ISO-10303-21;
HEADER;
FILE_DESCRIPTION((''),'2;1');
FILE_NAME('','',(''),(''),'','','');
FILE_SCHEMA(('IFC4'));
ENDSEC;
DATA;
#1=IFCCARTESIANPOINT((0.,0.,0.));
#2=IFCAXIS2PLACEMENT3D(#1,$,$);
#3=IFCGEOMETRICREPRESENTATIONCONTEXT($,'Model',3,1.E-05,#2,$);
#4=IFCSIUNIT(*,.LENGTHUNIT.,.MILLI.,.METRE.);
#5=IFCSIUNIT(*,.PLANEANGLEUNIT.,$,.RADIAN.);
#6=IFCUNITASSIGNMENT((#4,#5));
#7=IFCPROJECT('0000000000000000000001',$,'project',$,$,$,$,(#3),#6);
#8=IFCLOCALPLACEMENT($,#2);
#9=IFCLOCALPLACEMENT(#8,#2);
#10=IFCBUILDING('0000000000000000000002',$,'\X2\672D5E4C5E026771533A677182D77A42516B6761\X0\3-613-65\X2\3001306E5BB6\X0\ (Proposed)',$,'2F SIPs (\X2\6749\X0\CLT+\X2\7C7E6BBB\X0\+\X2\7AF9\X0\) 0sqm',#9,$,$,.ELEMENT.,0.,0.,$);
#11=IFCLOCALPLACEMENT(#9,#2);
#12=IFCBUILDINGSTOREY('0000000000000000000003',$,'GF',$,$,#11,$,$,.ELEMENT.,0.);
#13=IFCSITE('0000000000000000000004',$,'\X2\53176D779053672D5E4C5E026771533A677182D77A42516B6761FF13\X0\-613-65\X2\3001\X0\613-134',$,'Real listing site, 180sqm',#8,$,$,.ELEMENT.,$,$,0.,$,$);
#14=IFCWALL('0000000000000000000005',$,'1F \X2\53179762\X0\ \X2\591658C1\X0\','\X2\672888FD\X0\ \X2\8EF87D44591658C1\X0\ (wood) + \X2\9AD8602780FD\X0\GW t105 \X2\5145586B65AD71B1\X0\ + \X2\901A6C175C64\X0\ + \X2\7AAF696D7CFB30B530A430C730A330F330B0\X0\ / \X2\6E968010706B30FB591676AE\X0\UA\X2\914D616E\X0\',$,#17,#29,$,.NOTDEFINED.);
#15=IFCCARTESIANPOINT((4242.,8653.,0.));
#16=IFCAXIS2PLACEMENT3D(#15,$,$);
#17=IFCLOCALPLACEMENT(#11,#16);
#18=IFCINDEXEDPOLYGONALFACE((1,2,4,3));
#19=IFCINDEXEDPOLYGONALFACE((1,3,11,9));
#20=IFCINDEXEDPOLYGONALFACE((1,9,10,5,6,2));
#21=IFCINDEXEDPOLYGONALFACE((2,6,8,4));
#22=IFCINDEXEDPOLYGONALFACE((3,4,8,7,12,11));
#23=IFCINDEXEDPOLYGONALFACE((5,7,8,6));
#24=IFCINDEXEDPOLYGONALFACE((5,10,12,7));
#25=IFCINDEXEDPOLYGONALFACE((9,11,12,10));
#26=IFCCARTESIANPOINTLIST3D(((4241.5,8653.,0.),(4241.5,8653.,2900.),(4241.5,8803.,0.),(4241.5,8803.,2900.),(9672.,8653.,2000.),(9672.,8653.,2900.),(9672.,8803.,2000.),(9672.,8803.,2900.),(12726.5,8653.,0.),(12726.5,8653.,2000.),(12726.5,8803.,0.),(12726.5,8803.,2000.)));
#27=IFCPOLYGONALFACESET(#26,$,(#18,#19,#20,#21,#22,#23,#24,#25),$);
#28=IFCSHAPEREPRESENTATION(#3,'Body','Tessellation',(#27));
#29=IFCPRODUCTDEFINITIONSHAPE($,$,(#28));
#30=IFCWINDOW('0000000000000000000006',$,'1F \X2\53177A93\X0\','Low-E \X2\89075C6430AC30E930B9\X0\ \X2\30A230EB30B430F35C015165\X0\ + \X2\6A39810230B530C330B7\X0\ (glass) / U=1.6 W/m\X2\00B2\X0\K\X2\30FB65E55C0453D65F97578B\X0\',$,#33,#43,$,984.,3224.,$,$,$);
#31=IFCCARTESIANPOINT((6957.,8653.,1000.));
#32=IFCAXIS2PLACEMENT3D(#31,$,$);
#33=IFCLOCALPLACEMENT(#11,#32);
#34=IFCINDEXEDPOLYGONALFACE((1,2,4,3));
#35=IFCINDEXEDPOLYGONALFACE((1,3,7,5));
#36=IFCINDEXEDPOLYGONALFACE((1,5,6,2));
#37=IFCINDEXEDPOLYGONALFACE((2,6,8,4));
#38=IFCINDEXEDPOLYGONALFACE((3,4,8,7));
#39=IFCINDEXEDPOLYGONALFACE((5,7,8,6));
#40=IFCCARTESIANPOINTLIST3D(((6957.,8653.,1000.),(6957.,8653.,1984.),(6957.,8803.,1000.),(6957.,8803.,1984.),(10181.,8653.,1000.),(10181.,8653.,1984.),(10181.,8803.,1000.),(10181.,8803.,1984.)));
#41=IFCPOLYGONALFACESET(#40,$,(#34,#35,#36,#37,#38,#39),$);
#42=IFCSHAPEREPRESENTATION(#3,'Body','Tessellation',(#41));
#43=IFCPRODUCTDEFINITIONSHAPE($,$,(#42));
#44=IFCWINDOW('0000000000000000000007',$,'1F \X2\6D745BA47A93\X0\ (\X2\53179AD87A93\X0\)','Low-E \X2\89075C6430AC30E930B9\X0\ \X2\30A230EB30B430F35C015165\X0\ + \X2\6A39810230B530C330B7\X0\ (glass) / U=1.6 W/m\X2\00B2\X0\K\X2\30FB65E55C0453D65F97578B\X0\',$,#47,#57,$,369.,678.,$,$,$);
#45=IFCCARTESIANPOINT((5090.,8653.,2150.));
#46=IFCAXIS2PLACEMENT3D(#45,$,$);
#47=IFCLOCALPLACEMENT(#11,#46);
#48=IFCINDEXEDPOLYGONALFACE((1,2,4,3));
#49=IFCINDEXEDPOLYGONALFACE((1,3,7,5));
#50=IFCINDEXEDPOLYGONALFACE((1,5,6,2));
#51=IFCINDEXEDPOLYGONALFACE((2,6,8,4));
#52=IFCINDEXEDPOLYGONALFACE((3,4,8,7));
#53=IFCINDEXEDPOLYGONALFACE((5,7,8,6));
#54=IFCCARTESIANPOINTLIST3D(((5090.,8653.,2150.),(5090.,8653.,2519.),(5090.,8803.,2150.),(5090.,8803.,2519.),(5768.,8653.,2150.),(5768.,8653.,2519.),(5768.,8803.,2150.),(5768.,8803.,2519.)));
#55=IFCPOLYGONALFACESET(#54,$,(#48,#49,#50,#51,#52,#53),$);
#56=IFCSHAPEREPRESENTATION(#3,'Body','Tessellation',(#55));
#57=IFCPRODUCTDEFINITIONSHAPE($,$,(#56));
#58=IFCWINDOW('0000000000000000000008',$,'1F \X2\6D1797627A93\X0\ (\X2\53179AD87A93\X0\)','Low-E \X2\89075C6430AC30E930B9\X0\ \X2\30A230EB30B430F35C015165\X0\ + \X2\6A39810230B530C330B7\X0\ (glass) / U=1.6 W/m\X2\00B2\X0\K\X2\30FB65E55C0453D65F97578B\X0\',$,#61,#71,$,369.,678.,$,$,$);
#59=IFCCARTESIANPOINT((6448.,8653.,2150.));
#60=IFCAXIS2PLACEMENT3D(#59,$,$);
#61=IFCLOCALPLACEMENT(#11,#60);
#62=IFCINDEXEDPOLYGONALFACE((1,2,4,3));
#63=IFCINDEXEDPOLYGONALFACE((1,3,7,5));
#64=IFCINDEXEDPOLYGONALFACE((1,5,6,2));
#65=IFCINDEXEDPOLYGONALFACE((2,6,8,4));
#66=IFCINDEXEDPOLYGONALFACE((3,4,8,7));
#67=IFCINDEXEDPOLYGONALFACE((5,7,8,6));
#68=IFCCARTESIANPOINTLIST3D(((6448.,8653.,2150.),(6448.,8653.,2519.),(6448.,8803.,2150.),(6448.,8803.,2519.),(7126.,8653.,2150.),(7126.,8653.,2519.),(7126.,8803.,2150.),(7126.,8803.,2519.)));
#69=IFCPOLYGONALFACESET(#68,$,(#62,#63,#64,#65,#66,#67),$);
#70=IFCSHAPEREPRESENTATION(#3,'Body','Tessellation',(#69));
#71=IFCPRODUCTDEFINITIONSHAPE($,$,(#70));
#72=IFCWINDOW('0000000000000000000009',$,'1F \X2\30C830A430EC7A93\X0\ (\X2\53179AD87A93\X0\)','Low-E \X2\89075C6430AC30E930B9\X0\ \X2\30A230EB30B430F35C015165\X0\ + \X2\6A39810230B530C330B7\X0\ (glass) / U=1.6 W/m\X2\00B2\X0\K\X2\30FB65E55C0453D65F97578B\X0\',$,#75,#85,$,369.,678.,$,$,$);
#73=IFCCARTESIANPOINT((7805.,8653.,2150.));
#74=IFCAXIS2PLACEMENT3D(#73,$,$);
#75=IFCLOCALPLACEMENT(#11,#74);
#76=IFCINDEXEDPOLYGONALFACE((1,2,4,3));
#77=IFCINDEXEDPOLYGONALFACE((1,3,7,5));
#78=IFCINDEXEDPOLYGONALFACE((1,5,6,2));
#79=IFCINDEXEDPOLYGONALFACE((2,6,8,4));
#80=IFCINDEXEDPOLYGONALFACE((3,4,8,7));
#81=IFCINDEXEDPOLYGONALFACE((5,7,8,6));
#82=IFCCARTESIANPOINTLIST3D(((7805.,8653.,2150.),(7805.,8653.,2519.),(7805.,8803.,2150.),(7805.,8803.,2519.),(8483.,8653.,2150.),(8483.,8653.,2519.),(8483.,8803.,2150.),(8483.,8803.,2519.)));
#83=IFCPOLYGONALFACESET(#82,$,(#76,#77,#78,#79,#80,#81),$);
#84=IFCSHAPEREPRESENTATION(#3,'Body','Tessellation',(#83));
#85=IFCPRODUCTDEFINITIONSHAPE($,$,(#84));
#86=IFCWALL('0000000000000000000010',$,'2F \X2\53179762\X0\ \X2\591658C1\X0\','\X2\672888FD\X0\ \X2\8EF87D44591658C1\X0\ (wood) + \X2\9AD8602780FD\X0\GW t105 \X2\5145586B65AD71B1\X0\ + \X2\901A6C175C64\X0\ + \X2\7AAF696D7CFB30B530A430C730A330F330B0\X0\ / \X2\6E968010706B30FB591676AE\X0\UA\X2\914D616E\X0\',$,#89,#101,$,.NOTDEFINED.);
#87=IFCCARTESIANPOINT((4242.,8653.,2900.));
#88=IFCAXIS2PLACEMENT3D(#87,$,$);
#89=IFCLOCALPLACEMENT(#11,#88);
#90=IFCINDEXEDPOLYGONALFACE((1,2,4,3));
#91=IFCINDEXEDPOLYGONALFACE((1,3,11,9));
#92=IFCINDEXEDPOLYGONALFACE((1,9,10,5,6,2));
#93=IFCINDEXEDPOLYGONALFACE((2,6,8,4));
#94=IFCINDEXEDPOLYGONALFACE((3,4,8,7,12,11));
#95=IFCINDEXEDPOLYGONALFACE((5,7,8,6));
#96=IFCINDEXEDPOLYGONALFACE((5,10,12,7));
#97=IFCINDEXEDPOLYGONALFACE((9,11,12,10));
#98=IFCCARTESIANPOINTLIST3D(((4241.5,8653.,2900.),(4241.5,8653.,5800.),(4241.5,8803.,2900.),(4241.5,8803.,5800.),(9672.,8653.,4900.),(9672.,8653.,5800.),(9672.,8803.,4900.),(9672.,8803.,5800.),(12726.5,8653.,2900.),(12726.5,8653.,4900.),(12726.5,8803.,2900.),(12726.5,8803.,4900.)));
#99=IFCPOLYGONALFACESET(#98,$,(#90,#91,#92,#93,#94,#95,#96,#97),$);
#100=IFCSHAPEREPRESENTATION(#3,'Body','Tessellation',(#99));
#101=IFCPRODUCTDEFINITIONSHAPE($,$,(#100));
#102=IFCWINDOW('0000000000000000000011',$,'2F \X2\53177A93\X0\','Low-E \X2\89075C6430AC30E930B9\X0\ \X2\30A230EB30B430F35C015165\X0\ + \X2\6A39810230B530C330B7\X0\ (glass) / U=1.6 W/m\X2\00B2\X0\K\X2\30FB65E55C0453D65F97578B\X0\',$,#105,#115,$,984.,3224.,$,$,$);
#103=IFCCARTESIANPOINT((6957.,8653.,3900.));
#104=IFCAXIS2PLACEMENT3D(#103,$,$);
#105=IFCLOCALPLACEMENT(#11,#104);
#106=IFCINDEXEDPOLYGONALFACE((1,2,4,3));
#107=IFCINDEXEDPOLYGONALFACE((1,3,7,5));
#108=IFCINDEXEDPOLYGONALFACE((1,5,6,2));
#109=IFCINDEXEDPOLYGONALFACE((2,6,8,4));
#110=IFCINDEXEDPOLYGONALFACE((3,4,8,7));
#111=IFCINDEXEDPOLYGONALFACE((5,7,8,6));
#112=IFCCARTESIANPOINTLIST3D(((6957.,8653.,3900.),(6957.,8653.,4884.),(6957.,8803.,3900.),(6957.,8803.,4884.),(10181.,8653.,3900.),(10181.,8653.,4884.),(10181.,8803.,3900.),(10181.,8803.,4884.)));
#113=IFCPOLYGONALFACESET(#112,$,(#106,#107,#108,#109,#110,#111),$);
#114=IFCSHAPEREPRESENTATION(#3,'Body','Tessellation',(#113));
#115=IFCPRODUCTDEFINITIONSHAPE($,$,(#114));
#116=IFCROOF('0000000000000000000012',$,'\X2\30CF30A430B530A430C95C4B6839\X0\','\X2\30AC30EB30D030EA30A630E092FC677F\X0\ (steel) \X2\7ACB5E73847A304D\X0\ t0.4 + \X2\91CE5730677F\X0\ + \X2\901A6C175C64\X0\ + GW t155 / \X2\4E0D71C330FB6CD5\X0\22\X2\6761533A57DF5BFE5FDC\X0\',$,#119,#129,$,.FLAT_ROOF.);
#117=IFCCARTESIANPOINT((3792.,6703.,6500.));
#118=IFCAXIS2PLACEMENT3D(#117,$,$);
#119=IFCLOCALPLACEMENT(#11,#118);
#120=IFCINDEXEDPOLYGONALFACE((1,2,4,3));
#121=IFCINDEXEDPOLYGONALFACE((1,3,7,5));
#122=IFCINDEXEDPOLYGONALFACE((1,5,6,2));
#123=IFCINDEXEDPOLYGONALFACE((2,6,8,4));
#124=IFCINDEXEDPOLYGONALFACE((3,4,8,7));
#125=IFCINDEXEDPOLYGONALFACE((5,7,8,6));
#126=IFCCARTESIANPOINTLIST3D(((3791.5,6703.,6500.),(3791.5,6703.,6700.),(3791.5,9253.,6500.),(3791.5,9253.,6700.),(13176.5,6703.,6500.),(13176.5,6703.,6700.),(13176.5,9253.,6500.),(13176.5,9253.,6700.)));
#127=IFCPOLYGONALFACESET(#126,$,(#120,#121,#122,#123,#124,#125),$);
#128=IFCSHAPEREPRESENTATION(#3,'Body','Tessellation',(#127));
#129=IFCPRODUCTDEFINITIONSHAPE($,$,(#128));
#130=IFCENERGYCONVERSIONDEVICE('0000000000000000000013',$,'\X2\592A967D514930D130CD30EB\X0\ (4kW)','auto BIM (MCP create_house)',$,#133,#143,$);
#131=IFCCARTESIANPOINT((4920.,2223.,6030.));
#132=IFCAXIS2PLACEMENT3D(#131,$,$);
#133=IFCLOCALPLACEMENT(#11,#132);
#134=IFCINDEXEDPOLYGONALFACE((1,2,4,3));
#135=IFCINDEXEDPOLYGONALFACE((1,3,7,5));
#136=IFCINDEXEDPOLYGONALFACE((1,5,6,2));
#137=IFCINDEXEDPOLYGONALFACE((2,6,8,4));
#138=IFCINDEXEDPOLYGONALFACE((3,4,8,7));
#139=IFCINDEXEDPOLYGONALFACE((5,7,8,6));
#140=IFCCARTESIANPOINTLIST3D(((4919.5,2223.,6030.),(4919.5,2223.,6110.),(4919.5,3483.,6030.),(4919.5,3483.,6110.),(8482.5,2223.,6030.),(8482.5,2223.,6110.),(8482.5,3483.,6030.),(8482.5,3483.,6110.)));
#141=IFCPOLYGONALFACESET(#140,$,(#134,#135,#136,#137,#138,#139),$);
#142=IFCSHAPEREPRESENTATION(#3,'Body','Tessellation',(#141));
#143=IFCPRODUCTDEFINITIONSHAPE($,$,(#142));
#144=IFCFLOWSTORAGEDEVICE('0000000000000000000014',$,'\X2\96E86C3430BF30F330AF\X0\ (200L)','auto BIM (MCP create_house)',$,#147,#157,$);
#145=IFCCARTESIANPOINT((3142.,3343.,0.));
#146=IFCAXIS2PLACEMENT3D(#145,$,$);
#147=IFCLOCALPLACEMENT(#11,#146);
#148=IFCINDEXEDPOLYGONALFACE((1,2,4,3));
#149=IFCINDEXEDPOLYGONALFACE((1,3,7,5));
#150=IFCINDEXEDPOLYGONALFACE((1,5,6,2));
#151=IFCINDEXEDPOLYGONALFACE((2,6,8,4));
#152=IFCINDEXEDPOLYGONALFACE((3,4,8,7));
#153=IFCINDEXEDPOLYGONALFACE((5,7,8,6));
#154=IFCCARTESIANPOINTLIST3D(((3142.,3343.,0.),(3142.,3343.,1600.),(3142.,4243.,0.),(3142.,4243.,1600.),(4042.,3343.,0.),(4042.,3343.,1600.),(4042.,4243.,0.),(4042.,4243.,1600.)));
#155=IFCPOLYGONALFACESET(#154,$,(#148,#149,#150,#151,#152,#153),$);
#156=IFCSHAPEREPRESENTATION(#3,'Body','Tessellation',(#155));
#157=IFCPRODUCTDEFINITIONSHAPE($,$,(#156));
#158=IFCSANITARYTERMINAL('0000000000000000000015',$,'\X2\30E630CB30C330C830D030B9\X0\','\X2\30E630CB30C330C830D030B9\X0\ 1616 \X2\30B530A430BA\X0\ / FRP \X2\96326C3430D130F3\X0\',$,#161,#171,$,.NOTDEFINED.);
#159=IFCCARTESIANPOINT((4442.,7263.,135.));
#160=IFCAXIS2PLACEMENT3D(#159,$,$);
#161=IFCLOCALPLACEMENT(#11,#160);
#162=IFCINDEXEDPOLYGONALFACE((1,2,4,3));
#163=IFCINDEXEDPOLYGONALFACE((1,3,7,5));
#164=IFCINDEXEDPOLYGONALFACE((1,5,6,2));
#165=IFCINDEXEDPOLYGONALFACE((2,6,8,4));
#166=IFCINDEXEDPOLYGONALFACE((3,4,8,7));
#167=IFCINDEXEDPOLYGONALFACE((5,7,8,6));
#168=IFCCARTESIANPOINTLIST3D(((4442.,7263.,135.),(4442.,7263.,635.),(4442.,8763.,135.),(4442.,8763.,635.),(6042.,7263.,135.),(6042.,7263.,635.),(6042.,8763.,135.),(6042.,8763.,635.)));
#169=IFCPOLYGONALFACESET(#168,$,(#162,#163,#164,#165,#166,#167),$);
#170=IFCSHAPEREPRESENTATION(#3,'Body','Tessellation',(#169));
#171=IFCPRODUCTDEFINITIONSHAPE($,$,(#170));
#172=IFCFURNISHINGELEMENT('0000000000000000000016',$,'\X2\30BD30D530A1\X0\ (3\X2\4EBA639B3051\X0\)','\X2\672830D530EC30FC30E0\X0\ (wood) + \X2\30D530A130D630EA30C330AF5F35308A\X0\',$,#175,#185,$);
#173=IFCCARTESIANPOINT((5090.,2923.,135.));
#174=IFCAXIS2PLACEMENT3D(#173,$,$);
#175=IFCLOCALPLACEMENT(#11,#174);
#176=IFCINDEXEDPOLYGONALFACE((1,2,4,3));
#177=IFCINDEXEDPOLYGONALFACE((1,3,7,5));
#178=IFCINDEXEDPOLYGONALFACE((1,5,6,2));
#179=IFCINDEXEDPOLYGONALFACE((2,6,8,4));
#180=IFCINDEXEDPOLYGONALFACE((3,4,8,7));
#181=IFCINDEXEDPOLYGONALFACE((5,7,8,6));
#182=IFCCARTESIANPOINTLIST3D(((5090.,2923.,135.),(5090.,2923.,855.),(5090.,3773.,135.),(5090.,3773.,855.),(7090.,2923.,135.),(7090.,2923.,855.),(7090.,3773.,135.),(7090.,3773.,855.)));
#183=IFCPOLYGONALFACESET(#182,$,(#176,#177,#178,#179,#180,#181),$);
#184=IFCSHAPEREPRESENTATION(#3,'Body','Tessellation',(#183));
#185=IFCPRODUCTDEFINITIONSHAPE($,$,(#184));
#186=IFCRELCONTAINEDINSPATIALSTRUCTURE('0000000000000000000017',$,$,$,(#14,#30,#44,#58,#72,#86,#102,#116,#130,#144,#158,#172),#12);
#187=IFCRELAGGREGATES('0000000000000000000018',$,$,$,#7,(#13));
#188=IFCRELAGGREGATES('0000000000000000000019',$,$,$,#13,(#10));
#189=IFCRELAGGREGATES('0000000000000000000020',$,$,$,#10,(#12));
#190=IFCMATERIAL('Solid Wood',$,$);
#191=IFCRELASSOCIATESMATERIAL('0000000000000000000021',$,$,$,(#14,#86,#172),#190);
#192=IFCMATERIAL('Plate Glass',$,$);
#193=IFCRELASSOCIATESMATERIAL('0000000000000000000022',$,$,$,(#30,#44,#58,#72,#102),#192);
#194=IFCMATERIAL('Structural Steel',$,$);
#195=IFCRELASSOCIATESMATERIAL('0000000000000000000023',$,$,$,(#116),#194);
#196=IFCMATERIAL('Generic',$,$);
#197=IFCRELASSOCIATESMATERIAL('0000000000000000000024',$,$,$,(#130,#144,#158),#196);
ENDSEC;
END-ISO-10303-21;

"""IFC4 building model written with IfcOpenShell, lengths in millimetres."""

from ifc_helpers import new_model, si_unit, frame, frame_2d, origin, place, context, project, spatial, rectangle, extrude, material, element, fill, save


model = new_model("IFC4")

# Units and contexts
model_context = context("Model", 3, precision=1e-05, world=origin())
ifc_project = project(units=[si_unit("LENGTHUNIT", "METRE", prefix="MILLI"), si_unit("PLANEANGLEUNIT", "RADIAN")], contexts=[model_context])

# Site, building, storey
site_placement = place(None, origin())
site = spatial("IfcSite", under=ifc_project, at=site_placement, Name="北海道札幌市東区東苗穂八条３-613-65、613-134", ObjectType="Real listing site, 180sqm", CompositionType="ELEMENT", RefElevation=0.0)
building_placement = place(site_placement, origin())
building = spatial("IfcBuilding", under=site, at=building_placement, Name="札幌市東区東苗穂八条3-613-65、の家 (Proposed)", ObjectType="2F SIPs (杉CLT+籾殻+竹) 0sqm", CompositionType="ELEMENT", ElevationOfRefHeight=0.0, ElevationOfTerrain=0.0)
storey_placement = place(building_placement, origin())
storey = spatial("IfcBuildingStorey", under=building, at=storey_placement, Name="GF", CompositionType="ELEMENT", Elevation=0.0)

# Wall, openings, windows
ifc_material_1 = material(Name="Solid Wood")
wall_1_placement = place(storey_placement, frame((4242.0, 8653.0, 0.0)))
wall_1 = element("IfcWall", 1, at=wall_1_placement, inside=storey, material=ifc_material_1, Name="1F 北面 外壁", Description="木製 軸組外壁 (wood) + 高性能GW t105 充填断熱 + 通気層 + 窯業系サイディング / 準耐火・外皮UA配慮", PredefinedType="NOTDEFINED", context=model_context, shape_type="SweptSolid", body=[
    extrude(rectangle(XDim=8485.0, YDim=150.0, at=frame_2d((4242.0, 75.0))), frame((4242.0, 8653.0, 0.0)), (0.0, 0.0, 1.0), 2900.0),
])
opening_1_placement = place(storey_placement, frame((6957.0, 8653.0, 1000.0)))
opening_1 = element("IfcOpeningElement", 2, at=opening_1_placement, cuts=wall_1, PredefinedType="NOTDEFINED", context=model_context, shape_type="SweptSolid", body=[
    extrude(rectangle(XDim=3224.0, YDim=150.0, at=frame_2d((1612.0, 75.0))), frame((6957.0, 8653.0, 1000.0)), (0.0, 0.0, 1.0), 984.0),
])
opening_2_placement = place(storey_placement, frame((5090.0, 8653.0, 2150.0)))
opening_2 = element("IfcOpeningElement", 3, at=opening_2_placement, cuts=wall_1, PredefinedType="NOTDEFINED", context=model_context, shape_type="SweptSolid", body=[
    extrude(rectangle(XDim=678.0, YDim=150.0, at=frame_2d((339.0, 75.0))), frame((5090.0, 8653.0, 2150.0)), (0.0, 0.0, 1.0), 369.0),
])
opening_3_placement = place(storey_placement, frame((6448.0, 8653.0, 2150.0)))
opening_3 = element("IfcOpeningElement", 4, at=opening_3_placement, cuts=wall_1, PredefinedType="NOTDEFINED", context=model_context, shape_type="SweptSolid", body=[
    extrude(rectangle(XDim=678.0, YDim=150.0, at=frame_2d((339.0, 75.0))), frame((6448.0, 8653.0, 2150.0)), (0.0, 0.0, 1.0), 369.0),
])
opening_4_placement = place(storey_placement, frame((7805.0, 8653.0, 2150.0)))
opening_4 = element("IfcOpeningElement", 5, at=opening_4_placement, cuts=wall_1, PredefinedType="NOTDEFINED", context=model_context, shape_type="SweptSolid", body=[
    extrude(rectangle(XDim=678.0, YDim=150.0, at=frame_2d((339.0, 75.0))), frame((7805.0, 8653.0, 2150.0)), (0.0, 0.0, 1.0), 369.0),
])
ifc_material_2 = material(Name="Plate Glass")
window_1_placement = place(storey_placement, frame((6957.0, 8653.0, 1000.0)))
window_1 = element("IfcWindow", 6, at=window_1_placement, inside=storey, material=ifc_material_2, Name="1F 北窓", Description="Low-E 複層ガラス アルゴン封入 + 樹脂サッシ (glass) / U=1.6 W/m²K・日射取得型", OverallHeight=984.0, OverallWidth=3224.0, context=model_context, shape_type="SweptSolid", body=[
    extrude(rectangle(XDim=3224.0, YDim=150.0, at=frame_2d((1612.0, 75.0))), frame((6957.0, 8653.0, 1000.0)), (0.0, 0.0, 1.0), 984.0),
])
fill(opening_1, window_1)
window_2_placement = place(storey_placement, frame((5090.0, 8653.0, 2150.0)))
window_2 = element("IfcWindow", 7, at=window_2_placement, inside=storey, material=ifc_material_2, Name="1F 浴室窓 (北高窓)", Description="Low-E 複層ガラス アルゴン封入 + 樹脂サッシ (glass) / U=1.6 W/m²K・日射取得型", OverallHeight=369.0, OverallWidth=678.0, context=model_context, shape_type="SweptSolid", body=[
    extrude(rectangle(XDim=678.0, YDim=150.0, at=frame_2d((339.0, 75.0))), frame((5090.0, 8653.0, 2150.0)), (0.0, 0.0, 1.0), 369.0),
])
fill(opening_2, window_2)
window_3_placement = place(storey_placement, frame((6448.0, 8653.0, 2150.0)))
window_3 = element("IfcWindow", 8, at=window_3_placement, inside=storey, material=ifc_material_2, Name="1F 洗面窓 (北高窓)", Description="Low-E 複層ガラス アルゴン封入 + 樹脂サッシ (glass) / U=1.6 W/m²K・日射取得型", OverallHeight=369.0, OverallWidth=678.0, context=model_context, shape_type="SweptSolid", body=[
    extrude(rectangle(XDim=678.0, YDim=150.0, at=frame_2d((339.0, 75.0))), frame((6448.0, 8653.0, 2150.0)), (0.0, 0.0, 1.0), 369.0),
])
fill(opening_3, window_3)
window_4_placement = place(storey_placement, frame((7805.0, 8653.0, 2150.0)))
window_4 = element("IfcWindow", 9, at=window_4_placement, inside=storey, material=ifc_material_2, Name="1F トイレ窓 (北高窓)", Description="Low-E 複層ガラス アルゴン封入 + 樹脂サッシ (glass) / U=1.6 W/m²K・日射取得型", OverallHeight=369.0, OverallWidth=678.0, context=model_context, shape_type="SweptSolid", body=[
    extrude(rectangle(XDim=678.0, YDim=150.0, at=frame_2d((339.0, 75.0))), frame((7805.0, 8653.0, 2150.0)), (0.0, 0.0, 1.0), 369.0),
])
fill(opening_4, window_4)

# Wall, opening, window
wall_2_placement = place(storey_placement, frame((4242.0, 8653.0, 2900.0)))
wall_2 = element("IfcWall", 10, at=wall_2_placement, inside=storey, material=ifc_material_1, Name="2F 北面 外壁", Description="木製 軸組外壁 (wood) + 高性能GW t105 充填断熱 + 通気層 + 窯業系サイディング / 準耐火・外皮UA配慮", PredefinedType="NOTDEFINED", context=model_context, shape_type="SweptSolid", body=[
    extrude(rectangle(XDim=8485.0, YDim=150.0, at=frame_2d((4242.0, 75.0))), frame((4242.0, 8653.0, 2900.0)), (0.0, 0.0, 1.0), 2900.0),
])
opening_5_placement = place(storey_placement, frame((6957.0, 8653.0, 3900.0)))
opening_5 = element("IfcOpeningElement", 11, at=opening_5_placement, cuts=wall_2, PredefinedType="NOTDEFINED", context=model_context, shape_type="SweptSolid", body=[
    extrude(rectangle(XDim=3224.0, YDim=150.0, at=frame_2d((1612.0, 75.0))), frame((6957.0, 8653.0, 3900.0)), (0.0, 0.0, 1.0), 984.0),
])
window_5_placement = place(storey_placement, frame((6957.0, 8653.0, 3900.0)))
window_5 = element("IfcWindow", 12, at=window_5_placement, inside=storey, material=ifc_material_2, Name="2F 北窓", Description="Low-E 複層ガラス アルゴン封入 + 樹脂サッシ (glass) / U=1.6 W/m²K・日射取得型", OverallHeight=984.0, OverallWidth=3224.0, context=model_context, shape_type="SweptSolid", body=[
    extrude(rectangle(XDim=3224.0, YDim=150.0, at=frame_2d((1612.0, 75.0))), frame((6957.0, 8653.0, 3900.0)), (0.0, 0.0, 1.0), 984.0),
])
fill(opening_5, window_5)

# Roof
ifc_material_3 = material(Name="Structural Steel")
roof_placement = place(storey_placement, frame((3792.0, 6703.0, 6500.0)))
element("IfcRoof", 13, at=roof_placement, inside=storey, material=ifc_material_3, Name="ハイサイド屋根", Description="ガルバリウム鋼板 (steel) 立平葺き t0.4 + 野地板 + 通気層 + GW t155 / 不燃・法22条区域対応", PredefinedType="FLAT_ROOF", context=model_context, shape_type="SweptSolid", body=[
    extrude(rectangle(XDim=9385.0, YDim=2550.0, at=frame_2d((4692.0, 1275.0))), frame((3792.0, 6703.0, 6500.0)), (0.0, 0.0, 1.0), 200.0),
])

# Energy conversion device
ifc_material_4 = material(Name="Generic")
energy_conversion_device_placement = place(storey_placement, frame((4920.0, 2223.0, 6030.0)))
element("IfcEnergyConversionDevice", 14, at=energy_conversion_device_placement, inside=storey, material=ifc_material_4, Name="太陽光パネル (4kW)", Description="auto BIM (MCP create_house)", context=model_context, shape_type="SweptSolid", body=[
    extrude(rectangle(XDim=3563.0, YDim=1260.0, at=frame_2d((1781.0, 630.0))), frame((4920.0, 2223.0, 6030.0)), (0.0, 0.0, 1.0), 80.0),
])

# Flow storage device
flow_storage_device_placement = place(storey_placement, frame((3142.0, 3343.0, 0.0)))
element("IfcFlowStorageDevice", 15, at=flow_storage_device_placement, inside=storey, material=ifc_material_4, Name="雨水タンク (200L)", Description="auto BIM (MCP create_house)", context=model_context, shape_type="SweptSolid", body=[
    extrude(rectangle(XDim=900.0, YDim=900.0, at=frame_2d((450.0, 450.0))), frame((3142.0, 3343.0, 0.0)), (0.0, 0.0, 1.0), 1600.0),
])

# Sanitary terminal
sanitary_terminal_placement = place(storey_placement, frame((4442.0, 7263.0, 135.0)))
element("IfcSanitaryTerminal", 16, at=sanitary_terminal_placement, inside=storey, material=ifc_material_4, Name="ユニットバス", Description="ユニットバス 1616 サイズ / FRP 防水パン", PredefinedType="NOTDEFINED", context=model_context, shape_type="SweptSolid", body=[
    extrude(rectangle(XDim=1600.0, YDim=1500.0, at=frame_2d((800.0, 750.0))), frame((4442.0, 7263.0, 135.0)), (0.0, 0.0, 1.0), 500.0),
])

# Furnishing element
furnishing_1_placement = place(storey_placement, frame((5090.0, 2923.0, 135.0)))
element("IfcFurnishingElement", 17, at=furnishing_1_placement, inside=storey, material=ifc_material_1, Name="ソファ (3人掛け)", Description="木フレーム (wood) + ファブリック張り", context=model_context, shape_type="SweptSolid", body=[
    extrude(rectangle(XDim=2000.0, YDim=850.0, at=frame_2d((1000.0, 425.0))), frame((5090.0, 2923.0, 135.0)), (0.0, 0.0, 1.0), 720.0),
])

save(model, "model.ifc")
